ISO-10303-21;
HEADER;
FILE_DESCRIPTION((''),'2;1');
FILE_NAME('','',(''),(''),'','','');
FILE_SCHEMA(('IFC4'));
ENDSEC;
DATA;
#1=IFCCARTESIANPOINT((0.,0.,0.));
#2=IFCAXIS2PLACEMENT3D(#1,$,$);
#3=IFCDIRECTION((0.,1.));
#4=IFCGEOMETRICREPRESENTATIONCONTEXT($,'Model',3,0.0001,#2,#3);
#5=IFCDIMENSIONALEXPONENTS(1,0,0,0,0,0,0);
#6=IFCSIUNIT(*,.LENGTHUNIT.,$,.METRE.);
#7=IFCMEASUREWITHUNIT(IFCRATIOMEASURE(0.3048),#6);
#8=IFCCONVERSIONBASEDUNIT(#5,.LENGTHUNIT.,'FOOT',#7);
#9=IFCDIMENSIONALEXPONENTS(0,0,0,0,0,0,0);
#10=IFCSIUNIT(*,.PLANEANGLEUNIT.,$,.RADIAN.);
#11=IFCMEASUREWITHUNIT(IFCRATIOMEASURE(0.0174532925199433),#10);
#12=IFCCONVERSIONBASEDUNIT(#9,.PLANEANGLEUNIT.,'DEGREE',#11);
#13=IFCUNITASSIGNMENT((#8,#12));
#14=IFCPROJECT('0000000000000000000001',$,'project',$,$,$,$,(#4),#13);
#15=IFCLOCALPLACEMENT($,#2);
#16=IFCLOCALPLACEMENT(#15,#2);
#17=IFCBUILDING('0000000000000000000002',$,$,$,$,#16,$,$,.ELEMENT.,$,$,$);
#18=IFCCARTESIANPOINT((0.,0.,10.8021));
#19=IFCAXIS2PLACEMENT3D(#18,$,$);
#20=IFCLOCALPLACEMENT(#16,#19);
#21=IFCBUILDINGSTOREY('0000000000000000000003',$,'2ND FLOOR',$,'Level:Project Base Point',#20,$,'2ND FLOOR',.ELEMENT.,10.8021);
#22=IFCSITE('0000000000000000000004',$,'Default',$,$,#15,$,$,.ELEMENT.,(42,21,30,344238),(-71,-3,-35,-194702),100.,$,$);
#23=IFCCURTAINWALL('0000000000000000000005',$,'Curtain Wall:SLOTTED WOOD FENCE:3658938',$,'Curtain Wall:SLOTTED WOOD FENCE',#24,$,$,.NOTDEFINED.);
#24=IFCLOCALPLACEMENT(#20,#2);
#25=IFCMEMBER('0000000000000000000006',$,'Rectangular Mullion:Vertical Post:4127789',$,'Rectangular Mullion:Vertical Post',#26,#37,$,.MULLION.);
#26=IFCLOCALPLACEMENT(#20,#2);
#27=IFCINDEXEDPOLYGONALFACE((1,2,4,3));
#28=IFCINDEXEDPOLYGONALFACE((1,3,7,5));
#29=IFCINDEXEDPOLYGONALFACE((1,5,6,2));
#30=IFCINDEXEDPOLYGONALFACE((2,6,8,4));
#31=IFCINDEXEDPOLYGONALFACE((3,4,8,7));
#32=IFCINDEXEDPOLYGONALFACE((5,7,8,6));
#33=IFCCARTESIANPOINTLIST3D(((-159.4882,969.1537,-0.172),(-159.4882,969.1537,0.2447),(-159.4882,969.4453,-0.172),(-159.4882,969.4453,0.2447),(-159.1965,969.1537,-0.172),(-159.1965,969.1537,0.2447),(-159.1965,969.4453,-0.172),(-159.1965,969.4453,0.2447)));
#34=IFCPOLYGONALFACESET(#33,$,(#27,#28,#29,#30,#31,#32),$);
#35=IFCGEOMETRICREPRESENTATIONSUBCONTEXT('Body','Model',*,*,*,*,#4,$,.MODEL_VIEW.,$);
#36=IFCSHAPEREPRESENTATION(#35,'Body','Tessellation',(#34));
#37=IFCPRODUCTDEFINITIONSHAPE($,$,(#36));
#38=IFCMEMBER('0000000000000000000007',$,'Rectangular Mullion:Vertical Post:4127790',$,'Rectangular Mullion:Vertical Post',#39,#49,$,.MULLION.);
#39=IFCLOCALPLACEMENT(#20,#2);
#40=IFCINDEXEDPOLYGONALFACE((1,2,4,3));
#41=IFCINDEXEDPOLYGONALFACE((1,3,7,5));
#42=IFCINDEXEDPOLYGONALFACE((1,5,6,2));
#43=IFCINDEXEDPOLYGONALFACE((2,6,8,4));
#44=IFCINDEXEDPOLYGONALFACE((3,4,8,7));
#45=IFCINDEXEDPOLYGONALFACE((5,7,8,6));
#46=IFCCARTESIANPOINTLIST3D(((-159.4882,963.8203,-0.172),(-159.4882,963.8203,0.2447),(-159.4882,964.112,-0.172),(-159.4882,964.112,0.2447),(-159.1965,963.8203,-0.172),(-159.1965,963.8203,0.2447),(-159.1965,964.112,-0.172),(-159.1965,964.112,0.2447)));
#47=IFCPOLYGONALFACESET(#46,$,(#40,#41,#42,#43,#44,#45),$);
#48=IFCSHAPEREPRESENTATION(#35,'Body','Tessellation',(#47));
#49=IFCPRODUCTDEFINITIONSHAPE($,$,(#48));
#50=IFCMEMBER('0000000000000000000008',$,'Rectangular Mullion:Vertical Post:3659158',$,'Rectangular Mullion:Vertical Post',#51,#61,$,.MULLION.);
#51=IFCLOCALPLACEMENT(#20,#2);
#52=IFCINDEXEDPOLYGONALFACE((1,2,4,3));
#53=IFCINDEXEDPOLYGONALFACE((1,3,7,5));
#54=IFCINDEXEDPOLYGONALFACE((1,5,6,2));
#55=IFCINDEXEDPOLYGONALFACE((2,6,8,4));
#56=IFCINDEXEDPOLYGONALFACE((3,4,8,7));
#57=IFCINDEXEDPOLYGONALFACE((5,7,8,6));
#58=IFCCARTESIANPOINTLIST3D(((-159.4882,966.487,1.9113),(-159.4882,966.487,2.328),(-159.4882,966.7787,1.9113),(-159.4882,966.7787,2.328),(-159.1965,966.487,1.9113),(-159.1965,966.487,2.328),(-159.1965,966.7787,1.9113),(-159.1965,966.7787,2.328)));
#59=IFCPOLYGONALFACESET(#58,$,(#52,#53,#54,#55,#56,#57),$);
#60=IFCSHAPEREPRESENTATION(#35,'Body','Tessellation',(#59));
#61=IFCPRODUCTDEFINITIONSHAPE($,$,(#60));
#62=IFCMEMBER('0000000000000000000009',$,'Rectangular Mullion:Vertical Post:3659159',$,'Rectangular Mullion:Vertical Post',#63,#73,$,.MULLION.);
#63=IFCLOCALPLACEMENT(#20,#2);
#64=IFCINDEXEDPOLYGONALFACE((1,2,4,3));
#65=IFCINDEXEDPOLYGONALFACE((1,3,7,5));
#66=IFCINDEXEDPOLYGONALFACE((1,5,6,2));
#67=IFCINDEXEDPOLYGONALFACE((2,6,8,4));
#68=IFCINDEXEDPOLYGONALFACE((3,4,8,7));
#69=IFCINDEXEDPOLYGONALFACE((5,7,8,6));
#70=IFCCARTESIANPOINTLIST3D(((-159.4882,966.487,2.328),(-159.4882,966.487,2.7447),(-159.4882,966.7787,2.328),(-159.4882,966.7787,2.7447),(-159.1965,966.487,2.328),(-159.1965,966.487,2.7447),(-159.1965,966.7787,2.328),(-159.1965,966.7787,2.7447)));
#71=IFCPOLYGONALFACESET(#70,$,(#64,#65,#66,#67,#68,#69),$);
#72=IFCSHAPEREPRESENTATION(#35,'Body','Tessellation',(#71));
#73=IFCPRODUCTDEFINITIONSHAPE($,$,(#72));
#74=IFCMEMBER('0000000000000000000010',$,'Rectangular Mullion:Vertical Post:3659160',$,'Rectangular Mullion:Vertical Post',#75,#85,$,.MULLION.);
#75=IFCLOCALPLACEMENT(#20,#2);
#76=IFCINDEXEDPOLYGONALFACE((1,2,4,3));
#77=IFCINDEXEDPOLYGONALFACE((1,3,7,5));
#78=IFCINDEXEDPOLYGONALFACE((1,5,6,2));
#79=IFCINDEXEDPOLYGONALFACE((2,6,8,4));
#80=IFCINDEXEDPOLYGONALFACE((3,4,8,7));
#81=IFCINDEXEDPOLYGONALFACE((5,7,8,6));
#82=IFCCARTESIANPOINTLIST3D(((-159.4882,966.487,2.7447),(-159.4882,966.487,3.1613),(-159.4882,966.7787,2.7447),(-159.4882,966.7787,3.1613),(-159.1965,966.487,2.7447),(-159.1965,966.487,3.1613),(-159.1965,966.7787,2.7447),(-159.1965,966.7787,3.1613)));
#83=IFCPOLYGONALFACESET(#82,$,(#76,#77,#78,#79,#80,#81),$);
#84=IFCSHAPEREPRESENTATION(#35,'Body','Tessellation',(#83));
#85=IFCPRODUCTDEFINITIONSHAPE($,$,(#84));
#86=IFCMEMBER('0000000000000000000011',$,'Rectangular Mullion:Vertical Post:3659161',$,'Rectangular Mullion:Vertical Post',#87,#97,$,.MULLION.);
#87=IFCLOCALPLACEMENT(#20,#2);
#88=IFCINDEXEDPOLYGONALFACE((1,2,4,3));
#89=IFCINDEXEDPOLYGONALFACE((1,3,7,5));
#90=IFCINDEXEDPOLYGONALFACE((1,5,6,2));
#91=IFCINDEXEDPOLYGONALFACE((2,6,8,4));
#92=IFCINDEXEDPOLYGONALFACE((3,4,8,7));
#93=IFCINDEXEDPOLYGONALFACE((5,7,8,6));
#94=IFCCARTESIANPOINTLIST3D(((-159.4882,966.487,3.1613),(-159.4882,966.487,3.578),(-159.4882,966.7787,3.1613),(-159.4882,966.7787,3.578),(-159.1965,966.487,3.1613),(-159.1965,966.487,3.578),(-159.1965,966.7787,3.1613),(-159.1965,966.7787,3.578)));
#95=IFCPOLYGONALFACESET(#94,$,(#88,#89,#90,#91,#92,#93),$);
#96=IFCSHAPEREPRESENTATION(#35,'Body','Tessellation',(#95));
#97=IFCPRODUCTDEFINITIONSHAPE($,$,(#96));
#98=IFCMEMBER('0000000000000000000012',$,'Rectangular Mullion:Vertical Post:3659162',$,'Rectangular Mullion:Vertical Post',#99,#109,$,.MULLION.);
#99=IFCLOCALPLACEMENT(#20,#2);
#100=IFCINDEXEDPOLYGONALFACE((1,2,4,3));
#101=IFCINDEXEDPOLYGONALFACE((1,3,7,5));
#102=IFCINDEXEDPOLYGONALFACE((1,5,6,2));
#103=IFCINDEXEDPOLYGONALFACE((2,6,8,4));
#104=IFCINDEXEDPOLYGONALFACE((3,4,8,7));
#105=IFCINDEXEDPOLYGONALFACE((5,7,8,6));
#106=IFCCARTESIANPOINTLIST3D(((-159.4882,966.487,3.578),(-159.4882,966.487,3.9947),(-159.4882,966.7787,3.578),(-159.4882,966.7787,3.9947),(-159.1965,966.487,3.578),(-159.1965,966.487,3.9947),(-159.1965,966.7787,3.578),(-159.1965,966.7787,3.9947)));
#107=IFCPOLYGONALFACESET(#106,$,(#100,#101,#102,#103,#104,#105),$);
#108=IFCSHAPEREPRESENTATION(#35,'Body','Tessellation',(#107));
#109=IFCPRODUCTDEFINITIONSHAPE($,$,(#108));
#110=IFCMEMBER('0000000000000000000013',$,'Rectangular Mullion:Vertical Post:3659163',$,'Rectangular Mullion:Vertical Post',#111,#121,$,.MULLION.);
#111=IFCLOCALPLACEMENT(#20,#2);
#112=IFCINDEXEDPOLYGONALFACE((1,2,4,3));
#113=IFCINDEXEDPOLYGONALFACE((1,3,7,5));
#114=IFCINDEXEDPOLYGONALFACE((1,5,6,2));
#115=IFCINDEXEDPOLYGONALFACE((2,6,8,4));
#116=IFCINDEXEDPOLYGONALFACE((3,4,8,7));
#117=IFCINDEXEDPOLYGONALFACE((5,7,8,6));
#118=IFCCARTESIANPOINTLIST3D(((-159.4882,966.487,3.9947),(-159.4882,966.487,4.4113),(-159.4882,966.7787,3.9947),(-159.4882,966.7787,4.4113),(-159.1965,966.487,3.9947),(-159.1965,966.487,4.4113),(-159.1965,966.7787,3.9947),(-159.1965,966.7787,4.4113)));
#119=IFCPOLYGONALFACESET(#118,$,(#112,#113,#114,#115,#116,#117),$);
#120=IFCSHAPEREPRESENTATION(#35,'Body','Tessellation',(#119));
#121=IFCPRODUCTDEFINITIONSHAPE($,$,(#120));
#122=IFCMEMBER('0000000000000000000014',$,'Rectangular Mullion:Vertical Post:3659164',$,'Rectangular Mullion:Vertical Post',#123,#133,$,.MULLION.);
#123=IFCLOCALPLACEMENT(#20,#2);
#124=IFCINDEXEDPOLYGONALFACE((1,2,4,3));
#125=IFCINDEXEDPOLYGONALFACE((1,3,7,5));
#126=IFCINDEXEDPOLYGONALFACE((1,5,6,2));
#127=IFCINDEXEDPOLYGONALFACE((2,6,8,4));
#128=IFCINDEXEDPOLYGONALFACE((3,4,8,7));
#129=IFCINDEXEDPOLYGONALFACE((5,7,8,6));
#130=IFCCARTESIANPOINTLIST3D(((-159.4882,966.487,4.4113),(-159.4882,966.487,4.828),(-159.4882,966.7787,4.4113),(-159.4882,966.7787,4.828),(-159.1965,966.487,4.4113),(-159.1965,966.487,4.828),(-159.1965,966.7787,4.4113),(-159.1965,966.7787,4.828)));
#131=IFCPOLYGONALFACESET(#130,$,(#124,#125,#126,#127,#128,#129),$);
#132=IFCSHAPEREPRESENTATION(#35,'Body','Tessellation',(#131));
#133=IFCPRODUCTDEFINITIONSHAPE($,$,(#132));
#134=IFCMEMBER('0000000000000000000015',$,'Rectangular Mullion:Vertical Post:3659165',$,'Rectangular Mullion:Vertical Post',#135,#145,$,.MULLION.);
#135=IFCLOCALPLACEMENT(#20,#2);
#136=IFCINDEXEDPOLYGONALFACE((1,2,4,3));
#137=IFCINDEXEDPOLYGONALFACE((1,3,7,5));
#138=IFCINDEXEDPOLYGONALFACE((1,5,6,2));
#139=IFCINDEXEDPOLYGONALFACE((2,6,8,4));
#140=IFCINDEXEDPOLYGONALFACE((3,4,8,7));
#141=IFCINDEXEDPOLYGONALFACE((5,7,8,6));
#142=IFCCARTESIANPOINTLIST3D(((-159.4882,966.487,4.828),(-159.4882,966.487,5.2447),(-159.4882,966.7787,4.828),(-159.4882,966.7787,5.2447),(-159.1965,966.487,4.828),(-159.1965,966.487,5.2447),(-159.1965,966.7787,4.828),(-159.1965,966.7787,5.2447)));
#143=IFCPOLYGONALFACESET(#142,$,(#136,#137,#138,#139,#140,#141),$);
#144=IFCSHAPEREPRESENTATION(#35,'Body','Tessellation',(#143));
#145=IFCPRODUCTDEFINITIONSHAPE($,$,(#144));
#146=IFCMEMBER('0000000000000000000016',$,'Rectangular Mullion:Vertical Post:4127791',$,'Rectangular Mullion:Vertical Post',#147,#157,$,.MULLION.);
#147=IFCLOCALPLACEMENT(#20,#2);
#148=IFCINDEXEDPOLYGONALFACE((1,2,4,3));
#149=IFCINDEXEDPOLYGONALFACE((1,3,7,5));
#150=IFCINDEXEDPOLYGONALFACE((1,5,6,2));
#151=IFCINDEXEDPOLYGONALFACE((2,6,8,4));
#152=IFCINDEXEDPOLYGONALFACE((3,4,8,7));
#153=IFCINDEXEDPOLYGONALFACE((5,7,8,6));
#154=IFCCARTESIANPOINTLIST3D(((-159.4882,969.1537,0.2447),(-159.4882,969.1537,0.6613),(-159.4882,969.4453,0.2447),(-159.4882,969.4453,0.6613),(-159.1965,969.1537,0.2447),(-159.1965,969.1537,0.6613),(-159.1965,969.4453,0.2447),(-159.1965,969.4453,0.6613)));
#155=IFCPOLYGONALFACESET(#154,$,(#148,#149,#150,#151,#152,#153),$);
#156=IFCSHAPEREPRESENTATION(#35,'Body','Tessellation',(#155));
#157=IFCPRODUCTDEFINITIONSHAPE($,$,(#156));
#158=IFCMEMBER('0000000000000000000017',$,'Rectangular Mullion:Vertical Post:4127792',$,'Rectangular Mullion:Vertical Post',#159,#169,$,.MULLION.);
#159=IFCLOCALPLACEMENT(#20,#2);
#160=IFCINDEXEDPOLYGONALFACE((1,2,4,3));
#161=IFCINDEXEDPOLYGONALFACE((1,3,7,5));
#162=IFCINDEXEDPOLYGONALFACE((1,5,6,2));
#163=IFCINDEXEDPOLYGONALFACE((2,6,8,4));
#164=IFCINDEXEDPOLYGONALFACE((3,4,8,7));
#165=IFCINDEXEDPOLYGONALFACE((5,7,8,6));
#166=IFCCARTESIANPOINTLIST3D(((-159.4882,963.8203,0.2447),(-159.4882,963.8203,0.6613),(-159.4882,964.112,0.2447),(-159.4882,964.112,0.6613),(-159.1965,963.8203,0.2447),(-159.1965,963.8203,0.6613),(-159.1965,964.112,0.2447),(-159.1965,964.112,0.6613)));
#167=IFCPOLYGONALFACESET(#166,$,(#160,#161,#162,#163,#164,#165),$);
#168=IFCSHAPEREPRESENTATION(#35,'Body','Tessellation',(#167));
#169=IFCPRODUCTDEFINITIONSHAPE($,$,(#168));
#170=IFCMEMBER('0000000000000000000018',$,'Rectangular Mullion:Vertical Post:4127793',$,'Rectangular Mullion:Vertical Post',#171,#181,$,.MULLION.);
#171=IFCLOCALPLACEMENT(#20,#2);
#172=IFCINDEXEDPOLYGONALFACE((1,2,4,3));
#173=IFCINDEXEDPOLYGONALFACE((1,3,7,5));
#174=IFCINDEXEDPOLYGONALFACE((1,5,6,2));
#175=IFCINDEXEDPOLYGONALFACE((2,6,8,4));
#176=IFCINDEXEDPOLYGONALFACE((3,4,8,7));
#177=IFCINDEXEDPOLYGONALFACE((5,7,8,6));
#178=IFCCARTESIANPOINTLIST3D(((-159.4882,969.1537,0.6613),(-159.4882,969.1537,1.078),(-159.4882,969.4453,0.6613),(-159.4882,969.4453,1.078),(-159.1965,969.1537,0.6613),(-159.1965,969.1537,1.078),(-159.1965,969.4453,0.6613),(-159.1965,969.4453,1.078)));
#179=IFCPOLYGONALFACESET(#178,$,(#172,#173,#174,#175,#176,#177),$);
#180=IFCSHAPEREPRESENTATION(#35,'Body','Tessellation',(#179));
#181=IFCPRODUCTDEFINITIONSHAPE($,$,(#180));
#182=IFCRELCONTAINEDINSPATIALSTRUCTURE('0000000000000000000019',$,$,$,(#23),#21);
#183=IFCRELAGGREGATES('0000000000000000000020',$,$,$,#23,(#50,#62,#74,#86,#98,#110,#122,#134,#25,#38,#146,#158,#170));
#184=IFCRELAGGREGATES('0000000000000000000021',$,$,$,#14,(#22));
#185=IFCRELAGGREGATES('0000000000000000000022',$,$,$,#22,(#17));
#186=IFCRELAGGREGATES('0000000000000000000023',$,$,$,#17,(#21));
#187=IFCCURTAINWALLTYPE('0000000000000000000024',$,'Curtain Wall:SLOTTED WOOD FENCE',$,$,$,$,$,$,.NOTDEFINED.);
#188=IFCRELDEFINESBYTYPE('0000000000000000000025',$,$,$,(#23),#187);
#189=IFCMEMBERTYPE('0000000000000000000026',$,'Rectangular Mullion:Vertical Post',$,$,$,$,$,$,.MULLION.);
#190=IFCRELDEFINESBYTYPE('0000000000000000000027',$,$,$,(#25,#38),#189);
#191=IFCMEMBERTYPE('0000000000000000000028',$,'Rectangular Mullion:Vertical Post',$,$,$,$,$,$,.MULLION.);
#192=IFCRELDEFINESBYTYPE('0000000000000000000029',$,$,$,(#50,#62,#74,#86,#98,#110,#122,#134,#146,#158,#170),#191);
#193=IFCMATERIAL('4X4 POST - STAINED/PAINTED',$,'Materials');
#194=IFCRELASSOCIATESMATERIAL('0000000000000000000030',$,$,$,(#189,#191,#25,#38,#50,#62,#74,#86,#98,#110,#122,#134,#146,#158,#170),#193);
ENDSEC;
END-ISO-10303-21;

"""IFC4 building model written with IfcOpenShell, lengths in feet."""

from ifc_helpers import new_model, entity, si_unit, converted_unit, direction, frame, origin, origin_2d_with_axis, place, context, subcontext, project, spatial, rectangle, extrude, source, transform, mapped, material, material_profile, profile_set, profile_usage, type_object, type_shapes, element, aggregate, save


model = new_model("IFC4")

# Units and contexts
model_context = context("Model", 3, precision=0.0001, world=origin(), true_north=direction((0.0, 1.0)))
body_context = subcontext(model_context, "Body", "Model", "MODEL_VIEW")
ifc_project = project(units=[converted_unit("LENGTHUNIT", "FOOT", entity("IfcRatioMeasure", 0.3048), si_unit("LENGTHUNIT", "METRE"), dimensions=[1, 0, 0, 0, 0, 0, 0]), converted_unit("PLANEANGLEUNIT", "DEGREE", entity("IfcRatioMeasure", 0.0174532925199433), si_unit("PLANEANGLEUNIT", "RADIAN"), dimensions=[0, 0, 0, 0, 0, 0, 0])], contexts=[model_context])

# Site, building, storey
site_placement = place(None, origin())
site = spatial("IfcSite", under=ifc_project, at=site_placement, Name="Default", CompositionType="ELEMENT", RefLatitude=(42, 21, 30, 344238), RefLongitude=(-71, -3, -35, -194702), RefElevation=100.0)
building_placement = place(site_placement, origin())
building = spatial("IfcBuilding", under=site, at=building_placement, CompositionType="ELEMENT")
storey_placement = place(building_placement, frame((0.0, 0.0, 10.8021)))
storey = spatial("IfcBuildingStorey", under=building, at=storey_placement, Name="2ND FLOOR", ObjectType="Level:Project Base Point", LongName="2ND FLOOR", CompositionType="ELEMENT", Elevation=10.8021)

# Curtain wall, members
curtain_wall_type = type_object("IfcCurtainWallType", Name="Curtain Wall:SLOTTED WOOD FENCE", PredefinedType="NOTDEFINED")
curtain_wall_placement = place(storey_placement, frame((0.0, 0.0, -10.8021)))
curtain_wall = element("IfcCurtainWall", 1, at=curtain_wall_placement, inside=storey, type_object=curtain_wall_type, Name="Curtain Wall:SLOTTED WOOD FENCE:3658938", ObjectType="Curtain Wall:SLOTTED WOOD FENCE", PredefinedType="NOTDEFINED")
ifc_material = material(Name="4X4 POST - STAINED/PAINTED", Category="Materials")
ifc_material_profile = material_profile(ifc_material, rectangle(XDim=0.2917, YDim=0.2917, at=origin_2d_with_axis()), Name="Vertical Post")
ifc_profile_set = profile_set([ifc_material_profile], Name="Vertical Post")
ifc_profile_usage_1 = profile_usage(ifc_profile_set)
member_type_1 = type_object("IfcMemberType", Name="Rectangular Mullion:Vertical Post", PredefinedType="MULLION", material=ifc_profile_set)
shared_shape_1 = source(origin(), body_context, "Body", "SweptSolid", [
    extrude(rectangle(XDim=0.2917, YDim=0.2917, at=origin_2d_with_axis()), frame((0.0, -0.2083, -0.4167), z_axis=(0.0, 0.0, 1.0), x_axis=(0.0, -1.0, 0.0)), (0.0, 0.0, 1.0), 0.4167),
])
type_shapes(member_type_1, [shared_shape_1])
member_1_placement = place(storey_placement, frame((-159.5507, 969.2995, -0.172), z_axis=(0.0, 0.0, -1.0), x_axis=(0.0, -1.0, 0.0)))
member_1 = element("IfcMember", 2, at=member_1_placement, type_object=member_type_1, material=ifc_profile_usage_1, Name="Rectangular Mullion:Vertical Post:4127789", ObjectType="Rectangular Mullion:Vertical Post", PredefinedType="MULLION", context=body_context, shape_type="MappedRepresentation", body=[
    mapped(shared_shape_1, transform((0.0, 0.0, 0.0), scale=1.0)),
])
ifc_profile_usage_2 = profile_usage(ifc_profile_set)
member_2_placement = place(storey_placement, frame((-159.5507, 963.9662, -0.172), z_axis=(0.0, 0.0, -1.0), x_axis=(0.0, -1.0, 0.0)))
member_2 = element("IfcMember", 3, at=member_2_placement, type_object=member_type_1, material=ifc_profile_usage_2, Name="Rectangular Mullion:Vertical Post:4127790", ObjectType="Rectangular Mullion:Vertical Post", PredefinedType="MULLION", context=body_context, shape_type="MappedRepresentation", body=[
    mapped(shared_shape_1, transform((0.0, 0.0, 0.0), scale=1.0)),
])
ifc_profile_usage_3 = profile_usage(ifc_profile_set)
member_type_2 = type_object("IfcMemberType", Name="Rectangular Mullion:Vertical Post", PredefinedType="MULLION", material=ifc_profile_set)
shared_shape_2 = source(origin(), body_context, "Body", "SweptSolid", [
    extrude(rectangle(XDim=0.2917, YDim=0.2917, at=origin_2d_with_axis()), frame((0.0, -0.2083, -0.4167), z_axis=(0.0, 0.0, 1.0), x_axis=(0.0, -1.0, 0.0)), (0.0, 0.0, 1.0), 0.4167),
])
type_shapes(member_type_2, [shared_shape_2])
member_3_placement = place(storey_placement, frame((-159.5507, 966.6328, 1.9113), z_axis=(0.0, 0.0, -1.0), x_axis=(0.0, -1.0, 0.0)))
member_3 = element("IfcMember", 4, at=member_3_placement, type_object=member_type_2, material=ifc_profile_usage_3, Name="Rectangular Mullion:Vertical Post:3659158", ObjectType="Rectangular Mullion:Vertical Post", PredefinedType="MULLION", context=body_context, shape_type="MappedRepresentation", body=[
    mapped(shared_shape_2, transform((0.0, 0.0, 0.0), scale=1.0)),
])
ifc_profile_usage_4 = profile_usage(ifc_profile_set)
member_4_placement = place(storey_placement, frame((-159.5507, 966.6328, 2.328), z_axis=(0.0, 0.0, -1.0), x_axis=(0.0, -1.0, 0.0)))
member_4 = element("IfcMember", 5, at=member_4_placement, type_object=member_type_2, material=ifc_profile_usage_4, Name="Rectangular Mullion:Vertical Post:3659159", ObjectType="Rectangular Mullion:Vertical Post", PredefinedType="MULLION", context=body_context, shape_type="MappedRepresentation", body=[
    mapped(shared_shape_2, transform((0.0, 0.0, 0.0), scale=1.0)),
])
ifc_profile_usage_5 = profile_usage(ifc_profile_set)
member_5_placement = place(storey_placement, frame((-159.5507, 966.6328, 2.7447), z_axis=(0.0, 0.0, -1.0), x_axis=(0.0, -1.0, 0.0)))
member_5 = element("IfcMember", 6, at=member_5_placement, type_object=member_type_2, material=ifc_profile_usage_5, Name="Rectangular Mullion:Vertical Post:3659160", ObjectType="Rectangular Mullion:Vertical Post", PredefinedType="MULLION", context=body_context, shape_type="MappedRepresentation", body=[
    mapped(shared_shape_2, transform((0.0, 0.0, 0.0), scale=1.0)),
])
ifc_profile_usage_6 = profile_usage(ifc_profile_set)
member_6_placement = place(storey_placement, frame((-159.5507, 966.6328, 3.1613), z_axis=(0.0, 0.0, -1.0), x_axis=(0.0, -1.0, 0.0)))
member_6 = element("IfcMember", 7, at=member_6_placement, type_object=member_type_2, material=ifc_profile_usage_6, Name="Rectangular Mullion:Vertical Post:3659161", ObjectType="Rectangular Mullion:Vertical Post", PredefinedType="MULLION", context=body_context, shape_type="MappedRepresentation", body=[
    mapped(shared_shape_2, transform((0.0, 0.0, 0.0), scale=1.0)),
])
ifc_profile_usage_7 = profile_usage(ifc_profile_set)
member_7_placement = place(storey_placement, frame((-159.5507, 966.6328, 3.578), z_axis=(0.0, 0.0, -1.0), x_axis=(0.0, -1.0, 0.0)))
member_7 = element("IfcMember", 8, at=member_7_placement, type_object=member_type_2, material=ifc_profile_usage_7, Name="Rectangular Mullion:Vertical Post:3659162", ObjectType="Rectangular Mullion:Vertical Post", PredefinedType="MULLION", context=body_context, shape_type="MappedRepresentation", body=[
    mapped(shared_shape_2, transform((0.0, 0.0, 0.0), scale=1.0)),
])
ifc_profile_usage_8 = profile_usage(ifc_profile_set)
member_8_placement = place(storey_placement, frame((-159.5507, 966.6328, 3.9947), z_axis=(0.0, 0.0, -1.0), x_axis=(0.0, -1.0, 0.0)))
member_8 = element("IfcMember", 9, at=member_8_placement, type_object=member_type_2, material=ifc_profile_usage_8, Name="Rectangular Mullion:Vertical Post:3659163", ObjectType="Rectangular Mullion:Vertical Post", PredefinedType="MULLION", context=body_context, shape_type="MappedRepresentation", body=[
    mapped(shared_shape_2, transform((0.0, 0.0, 0.0), scale=1.0)),
])
ifc_profile_usage_9 = profile_usage(ifc_profile_set)
member_9_placement = place(storey_placement, frame((-159.5507, 966.6328, 4.4113), z_axis=(0.0, 0.0, -1.0), x_axis=(0.0, -1.0, 0.0)))
member_9 = element("IfcMember", 10, at=member_9_placement, type_object=member_type_2, material=ifc_profile_usage_9, Name="Rectangular Mullion:Vertical Post:3659164", ObjectType="Rectangular Mullion:Vertical Post", PredefinedType="MULLION", context=body_context, shape_type="MappedRepresentation", body=[
    mapped(shared_shape_2, transform((0.0, 0.0, 0.0), scale=1.0)),
])
ifc_profile_usage_10 = profile_usage(ifc_profile_set)
member_10_placement = place(storey_placement, frame((-159.5507, 966.6328, 4.828), z_axis=(0.0, 0.0, -1.0), x_axis=(0.0, -1.0, 0.0)))
member_10 = element("IfcMember", 11, at=member_10_placement, type_object=member_type_2, material=ifc_profile_usage_10, Name="Rectangular Mullion:Vertical Post:3659165", ObjectType="Rectangular Mullion:Vertical Post", PredefinedType="MULLION", context=body_context, shape_type="MappedRepresentation", body=[
    mapped(shared_shape_2, transform((0.0, 0.0, 0.0), scale=1.0)),
])
ifc_profile_usage_11 = profile_usage(ifc_profile_set)
member_11_placement = place(storey_placement, frame((-159.5507, 969.2995, 0.2447), z_axis=(0.0, 0.0, -1.0), x_axis=(0.0, -1.0, 0.0)))
member_11 = element("IfcMember", 12, at=member_11_placement, type_object=member_type_2, material=ifc_profile_usage_11, Name="Rectangular Mullion:Vertical Post:4127791", ObjectType="Rectangular Mullion:Vertical Post", PredefinedType="MULLION", context=body_context, shape_type="MappedRepresentation", body=[
    mapped(shared_shape_2, transform((0.0, 0.0, 0.0), scale=1.0)),
])
ifc_profile_usage_12 = profile_usage(ifc_profile_set)
member_12_placement = place(storey_placement, frame((-159.5507, 963.9662, 0.2447), z_axis=(0.0, 0.0, -1.0), x_axis=(0.0, -1.0, 0.0)))
member_12 = element("IfcMember", 13, at=member_12_placement, type_object=member_type_2, material=ifc_profile_usage_12, Name="Rectangular Mullion:Vertical Post:4127792", ObjectType="Rectangular Mullion:Vertical Post", PredefinedType="MULLION", context=body_context, shape_type="MappedRepresentation", body=[
    mapped(shared_shape_2, transform((0.0, 0.0, 0.0), scale=1.0)),
])
ifc_profile_usage_13 = profile_usage(ifc_profile_set)
member_13_placement = place(storey_placement, frame((-159.5507, 969.2995, 0.6613), z_axis=(0.0, 0.0, -1.0), x_axis=(0.0, -1.0, 0.0)))
member_13 = element("IfcMember", 14, at=member_13_placement, type_object=member_type_2, material=ifc_profile_usage_13, Name="Rectangular Mullion:Vertical Post:4127793", ObjectType="Rectangular Mullion:Vertical Post", PredefinedType="MULLION", context=body_context, shape_type="MappedRepresentation", body=[
    mapped(shared_shape_2, transform((0.0, 0.0, 0.0), scale=1.0)),
])
aggregate(curtain_wall, [member_3, member_4, member_5, member_6, member_7, member_8, member_9, member_10, member_1, member_2, member_11, member_12, member_13])

save(model, "model.ifc")
